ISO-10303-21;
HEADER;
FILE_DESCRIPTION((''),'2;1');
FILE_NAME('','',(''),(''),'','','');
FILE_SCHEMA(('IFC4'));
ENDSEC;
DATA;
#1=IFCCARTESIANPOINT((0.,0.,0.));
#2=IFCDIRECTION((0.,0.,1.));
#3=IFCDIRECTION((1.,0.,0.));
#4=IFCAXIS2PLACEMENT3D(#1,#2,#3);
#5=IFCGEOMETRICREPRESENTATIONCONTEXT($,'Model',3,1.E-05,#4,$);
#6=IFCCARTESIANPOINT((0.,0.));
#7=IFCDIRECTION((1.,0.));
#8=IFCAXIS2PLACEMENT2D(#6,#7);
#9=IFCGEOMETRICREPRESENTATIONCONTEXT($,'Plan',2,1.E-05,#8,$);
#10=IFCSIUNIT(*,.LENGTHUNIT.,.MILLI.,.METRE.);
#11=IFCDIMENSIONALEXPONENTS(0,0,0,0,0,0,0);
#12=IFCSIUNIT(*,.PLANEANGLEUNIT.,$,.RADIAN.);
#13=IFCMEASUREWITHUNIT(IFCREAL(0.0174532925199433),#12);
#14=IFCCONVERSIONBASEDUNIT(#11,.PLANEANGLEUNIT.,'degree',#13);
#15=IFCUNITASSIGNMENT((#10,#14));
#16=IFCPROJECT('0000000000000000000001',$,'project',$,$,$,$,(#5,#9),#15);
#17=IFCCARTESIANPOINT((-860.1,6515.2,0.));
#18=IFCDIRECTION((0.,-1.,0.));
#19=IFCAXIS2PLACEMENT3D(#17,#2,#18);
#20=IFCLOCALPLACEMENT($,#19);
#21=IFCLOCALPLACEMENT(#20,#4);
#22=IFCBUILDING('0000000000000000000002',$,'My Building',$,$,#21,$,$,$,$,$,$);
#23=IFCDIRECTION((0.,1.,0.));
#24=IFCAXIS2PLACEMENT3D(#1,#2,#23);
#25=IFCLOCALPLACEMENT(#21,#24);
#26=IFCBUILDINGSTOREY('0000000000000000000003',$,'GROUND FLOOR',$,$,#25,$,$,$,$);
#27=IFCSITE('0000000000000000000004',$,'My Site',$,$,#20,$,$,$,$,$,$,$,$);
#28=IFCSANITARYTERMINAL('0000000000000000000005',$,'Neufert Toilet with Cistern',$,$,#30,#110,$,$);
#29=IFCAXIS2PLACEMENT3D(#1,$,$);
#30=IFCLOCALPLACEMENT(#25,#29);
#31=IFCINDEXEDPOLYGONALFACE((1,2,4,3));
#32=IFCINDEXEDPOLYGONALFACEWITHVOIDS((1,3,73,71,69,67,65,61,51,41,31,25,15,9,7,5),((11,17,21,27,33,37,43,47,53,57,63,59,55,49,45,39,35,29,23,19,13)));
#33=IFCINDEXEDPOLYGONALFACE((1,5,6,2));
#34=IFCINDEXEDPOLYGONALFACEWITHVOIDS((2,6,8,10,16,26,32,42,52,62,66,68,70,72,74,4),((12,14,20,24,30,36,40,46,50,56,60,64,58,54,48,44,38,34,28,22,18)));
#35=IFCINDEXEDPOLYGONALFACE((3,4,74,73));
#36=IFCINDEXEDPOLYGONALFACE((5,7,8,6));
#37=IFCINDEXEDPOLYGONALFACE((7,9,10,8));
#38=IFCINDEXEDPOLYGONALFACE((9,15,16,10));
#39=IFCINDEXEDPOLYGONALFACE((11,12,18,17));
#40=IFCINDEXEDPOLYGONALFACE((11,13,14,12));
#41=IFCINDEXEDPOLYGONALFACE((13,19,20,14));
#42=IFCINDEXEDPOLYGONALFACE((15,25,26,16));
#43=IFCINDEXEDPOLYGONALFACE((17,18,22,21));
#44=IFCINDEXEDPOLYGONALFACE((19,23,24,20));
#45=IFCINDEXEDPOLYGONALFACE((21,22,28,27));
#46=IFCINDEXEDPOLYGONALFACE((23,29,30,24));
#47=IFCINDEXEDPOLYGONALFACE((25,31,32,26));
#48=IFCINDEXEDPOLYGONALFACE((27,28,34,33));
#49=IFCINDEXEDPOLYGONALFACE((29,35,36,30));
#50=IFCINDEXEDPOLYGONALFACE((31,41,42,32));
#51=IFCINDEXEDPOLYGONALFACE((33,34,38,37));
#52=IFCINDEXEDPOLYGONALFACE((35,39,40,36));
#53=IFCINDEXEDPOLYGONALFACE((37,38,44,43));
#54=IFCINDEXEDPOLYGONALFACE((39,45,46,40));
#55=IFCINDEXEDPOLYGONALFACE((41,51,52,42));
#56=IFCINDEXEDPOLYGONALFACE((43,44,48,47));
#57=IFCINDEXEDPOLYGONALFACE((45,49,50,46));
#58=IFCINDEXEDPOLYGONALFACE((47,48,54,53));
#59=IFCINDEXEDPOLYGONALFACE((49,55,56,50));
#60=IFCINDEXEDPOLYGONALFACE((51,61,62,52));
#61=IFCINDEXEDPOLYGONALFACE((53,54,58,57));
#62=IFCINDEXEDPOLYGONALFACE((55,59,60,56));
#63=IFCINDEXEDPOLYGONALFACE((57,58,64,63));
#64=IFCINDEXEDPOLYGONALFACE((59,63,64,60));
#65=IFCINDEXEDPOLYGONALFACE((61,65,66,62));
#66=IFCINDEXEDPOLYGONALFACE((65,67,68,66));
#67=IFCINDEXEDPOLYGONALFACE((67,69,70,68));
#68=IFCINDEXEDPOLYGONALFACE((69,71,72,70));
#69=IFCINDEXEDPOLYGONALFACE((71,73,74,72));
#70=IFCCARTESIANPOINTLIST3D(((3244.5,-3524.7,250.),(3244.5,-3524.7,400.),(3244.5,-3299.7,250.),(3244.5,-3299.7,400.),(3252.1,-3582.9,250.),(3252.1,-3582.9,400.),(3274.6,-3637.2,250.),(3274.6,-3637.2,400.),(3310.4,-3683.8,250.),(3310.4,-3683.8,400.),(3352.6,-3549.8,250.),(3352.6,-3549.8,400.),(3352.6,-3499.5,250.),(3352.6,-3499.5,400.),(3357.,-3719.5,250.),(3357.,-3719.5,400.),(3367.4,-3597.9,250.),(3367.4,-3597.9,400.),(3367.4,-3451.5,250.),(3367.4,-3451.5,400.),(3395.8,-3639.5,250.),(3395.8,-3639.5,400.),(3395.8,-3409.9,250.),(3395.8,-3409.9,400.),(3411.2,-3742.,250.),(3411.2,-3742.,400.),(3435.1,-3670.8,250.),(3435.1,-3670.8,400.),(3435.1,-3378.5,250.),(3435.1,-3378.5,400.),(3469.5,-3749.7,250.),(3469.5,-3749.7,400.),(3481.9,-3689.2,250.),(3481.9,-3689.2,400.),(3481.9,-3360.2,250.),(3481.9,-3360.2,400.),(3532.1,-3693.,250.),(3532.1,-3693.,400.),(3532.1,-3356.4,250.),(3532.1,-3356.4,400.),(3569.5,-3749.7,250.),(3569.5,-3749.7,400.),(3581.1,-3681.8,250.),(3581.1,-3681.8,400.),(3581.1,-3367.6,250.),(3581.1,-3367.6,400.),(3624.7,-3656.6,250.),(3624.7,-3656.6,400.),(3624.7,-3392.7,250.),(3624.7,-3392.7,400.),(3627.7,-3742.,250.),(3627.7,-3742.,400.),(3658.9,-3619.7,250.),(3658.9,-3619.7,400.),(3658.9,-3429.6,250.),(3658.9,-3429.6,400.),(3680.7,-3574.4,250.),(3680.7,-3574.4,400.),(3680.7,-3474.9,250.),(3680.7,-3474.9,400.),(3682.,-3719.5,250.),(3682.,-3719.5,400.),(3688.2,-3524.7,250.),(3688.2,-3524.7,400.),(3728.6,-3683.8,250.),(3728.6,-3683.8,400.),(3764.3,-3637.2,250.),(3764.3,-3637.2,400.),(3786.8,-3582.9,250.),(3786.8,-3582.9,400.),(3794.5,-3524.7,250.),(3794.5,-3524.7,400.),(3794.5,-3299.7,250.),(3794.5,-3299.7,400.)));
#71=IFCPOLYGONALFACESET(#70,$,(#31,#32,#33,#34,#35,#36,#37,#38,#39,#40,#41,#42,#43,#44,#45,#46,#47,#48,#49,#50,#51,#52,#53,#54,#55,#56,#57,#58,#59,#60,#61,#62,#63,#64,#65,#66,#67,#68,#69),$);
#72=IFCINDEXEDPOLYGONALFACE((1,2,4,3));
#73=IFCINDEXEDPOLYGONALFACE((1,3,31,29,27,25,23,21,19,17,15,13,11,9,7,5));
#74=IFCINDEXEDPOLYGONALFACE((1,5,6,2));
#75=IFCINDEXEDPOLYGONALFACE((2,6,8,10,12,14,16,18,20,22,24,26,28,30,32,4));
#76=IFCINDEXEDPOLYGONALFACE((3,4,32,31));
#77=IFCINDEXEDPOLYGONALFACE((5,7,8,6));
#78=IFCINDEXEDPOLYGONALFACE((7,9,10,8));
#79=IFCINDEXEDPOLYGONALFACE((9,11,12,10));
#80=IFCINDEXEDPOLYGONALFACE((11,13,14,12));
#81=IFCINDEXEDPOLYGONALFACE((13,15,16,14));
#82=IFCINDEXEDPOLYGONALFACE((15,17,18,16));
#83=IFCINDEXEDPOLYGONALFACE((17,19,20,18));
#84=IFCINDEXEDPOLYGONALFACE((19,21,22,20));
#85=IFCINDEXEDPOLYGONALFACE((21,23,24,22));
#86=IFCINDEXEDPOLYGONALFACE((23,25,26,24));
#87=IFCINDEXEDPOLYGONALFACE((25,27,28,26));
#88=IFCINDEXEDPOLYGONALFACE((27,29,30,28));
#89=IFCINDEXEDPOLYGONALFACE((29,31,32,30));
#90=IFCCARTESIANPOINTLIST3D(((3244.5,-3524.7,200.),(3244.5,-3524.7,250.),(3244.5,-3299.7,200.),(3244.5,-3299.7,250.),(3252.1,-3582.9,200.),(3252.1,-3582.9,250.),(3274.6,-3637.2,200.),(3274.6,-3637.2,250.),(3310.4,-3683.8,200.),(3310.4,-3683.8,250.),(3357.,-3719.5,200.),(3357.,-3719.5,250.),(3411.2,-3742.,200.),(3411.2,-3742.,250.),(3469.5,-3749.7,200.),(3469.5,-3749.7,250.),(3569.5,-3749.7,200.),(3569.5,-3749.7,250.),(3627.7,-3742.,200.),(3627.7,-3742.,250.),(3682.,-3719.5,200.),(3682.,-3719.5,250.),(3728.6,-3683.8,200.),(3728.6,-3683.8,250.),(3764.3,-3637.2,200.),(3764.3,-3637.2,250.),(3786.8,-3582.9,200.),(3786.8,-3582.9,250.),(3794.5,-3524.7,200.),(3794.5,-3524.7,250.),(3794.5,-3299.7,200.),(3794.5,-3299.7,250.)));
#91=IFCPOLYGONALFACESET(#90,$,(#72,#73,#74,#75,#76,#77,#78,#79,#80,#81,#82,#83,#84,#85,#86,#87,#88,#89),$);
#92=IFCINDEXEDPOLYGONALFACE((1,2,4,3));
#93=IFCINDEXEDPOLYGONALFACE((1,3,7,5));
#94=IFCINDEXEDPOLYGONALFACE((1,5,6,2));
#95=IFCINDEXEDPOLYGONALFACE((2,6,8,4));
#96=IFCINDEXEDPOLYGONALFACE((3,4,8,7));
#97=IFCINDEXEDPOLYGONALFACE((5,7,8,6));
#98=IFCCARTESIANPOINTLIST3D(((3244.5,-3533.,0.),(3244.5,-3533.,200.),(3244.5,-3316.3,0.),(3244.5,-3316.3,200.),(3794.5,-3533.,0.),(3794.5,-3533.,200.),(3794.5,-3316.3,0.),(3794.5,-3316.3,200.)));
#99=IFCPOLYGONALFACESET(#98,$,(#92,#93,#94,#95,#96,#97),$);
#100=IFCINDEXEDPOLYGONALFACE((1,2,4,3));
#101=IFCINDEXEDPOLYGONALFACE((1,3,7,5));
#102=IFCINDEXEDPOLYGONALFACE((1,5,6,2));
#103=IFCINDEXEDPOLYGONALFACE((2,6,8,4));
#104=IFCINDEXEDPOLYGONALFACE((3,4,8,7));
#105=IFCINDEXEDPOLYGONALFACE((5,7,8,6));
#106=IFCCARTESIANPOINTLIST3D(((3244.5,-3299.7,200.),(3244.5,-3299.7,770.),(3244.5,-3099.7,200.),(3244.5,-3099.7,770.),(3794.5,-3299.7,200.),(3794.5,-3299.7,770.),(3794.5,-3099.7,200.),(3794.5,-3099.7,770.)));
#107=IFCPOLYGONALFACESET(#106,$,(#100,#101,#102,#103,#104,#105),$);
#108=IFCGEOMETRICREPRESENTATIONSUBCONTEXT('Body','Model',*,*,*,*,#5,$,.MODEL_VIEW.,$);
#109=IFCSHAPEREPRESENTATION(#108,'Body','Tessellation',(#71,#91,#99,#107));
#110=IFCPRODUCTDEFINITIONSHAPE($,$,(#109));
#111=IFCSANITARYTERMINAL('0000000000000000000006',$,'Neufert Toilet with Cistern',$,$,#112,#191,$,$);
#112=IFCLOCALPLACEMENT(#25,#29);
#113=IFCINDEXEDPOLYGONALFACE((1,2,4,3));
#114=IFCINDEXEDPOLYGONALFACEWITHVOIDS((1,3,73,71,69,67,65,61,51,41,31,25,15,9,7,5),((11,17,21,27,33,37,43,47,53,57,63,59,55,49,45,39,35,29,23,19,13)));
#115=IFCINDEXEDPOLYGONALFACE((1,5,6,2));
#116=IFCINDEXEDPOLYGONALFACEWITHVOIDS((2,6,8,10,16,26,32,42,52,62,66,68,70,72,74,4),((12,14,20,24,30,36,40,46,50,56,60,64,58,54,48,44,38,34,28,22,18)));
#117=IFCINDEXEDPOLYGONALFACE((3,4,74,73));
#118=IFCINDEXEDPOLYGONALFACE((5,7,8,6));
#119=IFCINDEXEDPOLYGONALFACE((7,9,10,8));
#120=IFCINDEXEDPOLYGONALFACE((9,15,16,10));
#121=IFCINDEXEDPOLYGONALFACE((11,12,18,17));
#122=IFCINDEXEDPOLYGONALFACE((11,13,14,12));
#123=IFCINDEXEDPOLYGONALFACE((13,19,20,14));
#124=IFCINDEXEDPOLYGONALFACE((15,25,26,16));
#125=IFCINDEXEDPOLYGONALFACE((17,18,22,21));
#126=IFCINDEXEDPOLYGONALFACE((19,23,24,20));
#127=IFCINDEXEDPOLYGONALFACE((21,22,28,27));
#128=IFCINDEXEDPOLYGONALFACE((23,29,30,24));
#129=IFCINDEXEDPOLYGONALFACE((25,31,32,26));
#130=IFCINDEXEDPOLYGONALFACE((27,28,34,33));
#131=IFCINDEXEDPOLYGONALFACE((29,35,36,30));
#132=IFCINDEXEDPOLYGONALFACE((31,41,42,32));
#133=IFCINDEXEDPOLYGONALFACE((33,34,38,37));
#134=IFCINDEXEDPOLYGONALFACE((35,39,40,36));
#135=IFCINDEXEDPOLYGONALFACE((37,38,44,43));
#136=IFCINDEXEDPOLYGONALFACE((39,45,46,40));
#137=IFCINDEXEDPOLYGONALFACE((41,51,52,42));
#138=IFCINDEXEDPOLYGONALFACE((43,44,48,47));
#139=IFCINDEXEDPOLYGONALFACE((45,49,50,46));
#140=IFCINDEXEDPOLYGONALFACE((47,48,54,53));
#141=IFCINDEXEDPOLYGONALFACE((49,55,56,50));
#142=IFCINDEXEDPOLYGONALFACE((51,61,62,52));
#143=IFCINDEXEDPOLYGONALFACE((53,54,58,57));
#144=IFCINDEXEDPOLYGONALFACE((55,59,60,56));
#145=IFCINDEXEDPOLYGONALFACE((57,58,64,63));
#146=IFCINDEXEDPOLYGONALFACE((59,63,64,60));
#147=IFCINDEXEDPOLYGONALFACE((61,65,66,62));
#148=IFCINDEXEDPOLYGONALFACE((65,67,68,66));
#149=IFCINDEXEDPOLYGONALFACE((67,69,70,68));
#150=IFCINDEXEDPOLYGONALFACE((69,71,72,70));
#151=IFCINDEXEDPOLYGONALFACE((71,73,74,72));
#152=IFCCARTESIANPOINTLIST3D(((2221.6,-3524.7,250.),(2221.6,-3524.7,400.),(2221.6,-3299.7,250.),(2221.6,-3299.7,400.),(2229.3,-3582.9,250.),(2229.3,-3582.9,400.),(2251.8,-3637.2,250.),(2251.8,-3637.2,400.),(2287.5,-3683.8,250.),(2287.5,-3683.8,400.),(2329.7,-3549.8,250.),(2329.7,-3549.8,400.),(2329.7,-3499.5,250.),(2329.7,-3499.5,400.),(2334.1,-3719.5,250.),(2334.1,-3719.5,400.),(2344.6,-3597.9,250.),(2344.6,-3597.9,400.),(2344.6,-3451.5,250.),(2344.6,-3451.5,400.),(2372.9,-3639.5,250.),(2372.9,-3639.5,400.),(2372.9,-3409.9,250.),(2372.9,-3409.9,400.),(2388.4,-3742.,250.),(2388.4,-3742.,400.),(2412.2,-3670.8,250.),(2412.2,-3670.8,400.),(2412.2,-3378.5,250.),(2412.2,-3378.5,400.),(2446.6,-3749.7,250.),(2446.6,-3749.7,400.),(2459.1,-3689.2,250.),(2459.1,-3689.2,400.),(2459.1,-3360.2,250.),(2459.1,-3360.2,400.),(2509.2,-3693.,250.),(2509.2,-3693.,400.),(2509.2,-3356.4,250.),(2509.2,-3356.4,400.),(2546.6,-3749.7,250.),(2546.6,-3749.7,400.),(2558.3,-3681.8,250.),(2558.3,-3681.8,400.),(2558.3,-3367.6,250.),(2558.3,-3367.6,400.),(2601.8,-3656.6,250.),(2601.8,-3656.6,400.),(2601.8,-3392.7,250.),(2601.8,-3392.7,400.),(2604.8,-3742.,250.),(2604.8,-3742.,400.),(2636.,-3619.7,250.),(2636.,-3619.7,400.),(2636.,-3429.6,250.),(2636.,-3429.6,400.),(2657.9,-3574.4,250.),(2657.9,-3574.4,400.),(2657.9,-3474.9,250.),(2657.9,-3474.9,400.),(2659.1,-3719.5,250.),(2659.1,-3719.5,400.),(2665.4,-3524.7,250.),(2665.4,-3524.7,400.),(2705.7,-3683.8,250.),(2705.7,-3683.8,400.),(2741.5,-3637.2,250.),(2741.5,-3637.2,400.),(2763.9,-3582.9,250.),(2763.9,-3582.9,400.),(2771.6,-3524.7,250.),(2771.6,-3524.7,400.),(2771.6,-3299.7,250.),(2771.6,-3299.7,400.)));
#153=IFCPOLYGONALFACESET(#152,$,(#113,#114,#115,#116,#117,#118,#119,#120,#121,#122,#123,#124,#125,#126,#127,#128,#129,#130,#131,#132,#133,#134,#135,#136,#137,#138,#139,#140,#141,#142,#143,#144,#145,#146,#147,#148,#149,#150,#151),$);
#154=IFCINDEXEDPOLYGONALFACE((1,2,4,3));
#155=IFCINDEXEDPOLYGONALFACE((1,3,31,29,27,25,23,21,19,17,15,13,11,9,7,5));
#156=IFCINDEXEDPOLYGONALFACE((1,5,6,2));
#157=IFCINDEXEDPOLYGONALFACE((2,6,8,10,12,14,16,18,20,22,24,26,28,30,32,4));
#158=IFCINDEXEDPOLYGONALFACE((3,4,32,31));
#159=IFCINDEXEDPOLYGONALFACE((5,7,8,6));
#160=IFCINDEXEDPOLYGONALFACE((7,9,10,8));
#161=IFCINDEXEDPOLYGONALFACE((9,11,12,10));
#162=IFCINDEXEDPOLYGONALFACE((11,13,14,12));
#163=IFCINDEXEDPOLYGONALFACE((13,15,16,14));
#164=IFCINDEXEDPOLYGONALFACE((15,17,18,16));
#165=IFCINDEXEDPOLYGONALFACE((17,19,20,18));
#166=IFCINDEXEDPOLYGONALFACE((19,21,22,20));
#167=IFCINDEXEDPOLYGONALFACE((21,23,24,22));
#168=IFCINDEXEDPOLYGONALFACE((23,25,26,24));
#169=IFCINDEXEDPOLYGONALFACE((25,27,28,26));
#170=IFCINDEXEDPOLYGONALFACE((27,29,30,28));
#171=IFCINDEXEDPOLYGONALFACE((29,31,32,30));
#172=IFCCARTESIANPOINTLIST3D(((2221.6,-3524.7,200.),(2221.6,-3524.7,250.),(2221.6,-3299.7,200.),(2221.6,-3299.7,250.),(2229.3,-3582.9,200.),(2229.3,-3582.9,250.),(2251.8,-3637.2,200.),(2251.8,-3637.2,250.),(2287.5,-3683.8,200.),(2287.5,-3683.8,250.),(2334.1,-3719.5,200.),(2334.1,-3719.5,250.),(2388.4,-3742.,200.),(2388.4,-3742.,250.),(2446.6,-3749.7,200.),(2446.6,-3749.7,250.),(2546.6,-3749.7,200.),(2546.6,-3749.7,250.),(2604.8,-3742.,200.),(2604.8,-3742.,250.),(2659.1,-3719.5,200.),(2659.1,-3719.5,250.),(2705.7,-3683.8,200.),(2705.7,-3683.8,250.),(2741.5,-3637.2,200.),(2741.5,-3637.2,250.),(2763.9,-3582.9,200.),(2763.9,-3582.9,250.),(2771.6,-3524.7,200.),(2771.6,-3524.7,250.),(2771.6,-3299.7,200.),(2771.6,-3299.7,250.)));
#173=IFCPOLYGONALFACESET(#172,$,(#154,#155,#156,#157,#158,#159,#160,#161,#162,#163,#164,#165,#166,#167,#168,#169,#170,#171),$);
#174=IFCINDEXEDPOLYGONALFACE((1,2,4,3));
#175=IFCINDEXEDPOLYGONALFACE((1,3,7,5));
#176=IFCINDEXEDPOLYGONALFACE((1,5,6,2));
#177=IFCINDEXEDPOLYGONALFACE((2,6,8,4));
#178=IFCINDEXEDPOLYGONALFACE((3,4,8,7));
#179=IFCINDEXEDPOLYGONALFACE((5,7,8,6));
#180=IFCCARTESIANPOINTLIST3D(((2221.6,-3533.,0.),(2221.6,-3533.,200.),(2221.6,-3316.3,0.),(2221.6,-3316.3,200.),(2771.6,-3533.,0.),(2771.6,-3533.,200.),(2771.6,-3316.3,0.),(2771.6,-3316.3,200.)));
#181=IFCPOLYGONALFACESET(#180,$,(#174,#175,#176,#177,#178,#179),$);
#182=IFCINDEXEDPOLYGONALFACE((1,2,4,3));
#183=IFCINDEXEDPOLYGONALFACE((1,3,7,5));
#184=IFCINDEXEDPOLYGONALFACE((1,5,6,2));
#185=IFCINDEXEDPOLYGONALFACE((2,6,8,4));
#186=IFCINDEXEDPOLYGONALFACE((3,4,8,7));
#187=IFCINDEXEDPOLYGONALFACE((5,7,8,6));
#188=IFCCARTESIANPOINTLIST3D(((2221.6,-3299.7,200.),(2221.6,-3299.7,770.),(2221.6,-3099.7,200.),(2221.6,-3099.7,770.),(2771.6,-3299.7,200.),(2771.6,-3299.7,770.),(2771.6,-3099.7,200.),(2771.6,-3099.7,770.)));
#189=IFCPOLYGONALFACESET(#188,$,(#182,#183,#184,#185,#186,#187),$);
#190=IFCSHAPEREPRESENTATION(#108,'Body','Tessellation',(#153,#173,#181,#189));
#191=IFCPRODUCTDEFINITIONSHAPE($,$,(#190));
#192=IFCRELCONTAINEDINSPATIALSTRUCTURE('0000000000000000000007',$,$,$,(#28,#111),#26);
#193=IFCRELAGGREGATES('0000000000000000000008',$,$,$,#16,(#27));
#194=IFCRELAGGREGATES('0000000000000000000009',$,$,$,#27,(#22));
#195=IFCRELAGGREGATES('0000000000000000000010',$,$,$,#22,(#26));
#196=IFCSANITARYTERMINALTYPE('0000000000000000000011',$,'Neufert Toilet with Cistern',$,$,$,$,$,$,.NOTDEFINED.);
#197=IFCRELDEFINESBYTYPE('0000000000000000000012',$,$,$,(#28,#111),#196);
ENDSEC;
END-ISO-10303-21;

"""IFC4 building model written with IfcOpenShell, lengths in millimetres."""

from ifc_helpers import new_model, entity, si_unit, converted_unit, frame, frame_2d, origin_with_axes, origin_2d_with_axis, place, context, subcontext, project, spatial, line, arc, indexed_curve, circle_curve, outline, extrude, shape, source, transform, mapped, type_object, type_shapes, element, save


model = new_model("IFC4")

# Units and contexts
model_context = context("Model", 3, precision=1e-05, world=origin_with_axes())
plan_context = context("Plan", 2, precision=1e-05, world=origin_2d_with_axis())
body_context_1 = subcontext(model_context, "Body", "Model", "MODEL_VIEW")
body_context_2 = subcontext(plan_context, "Body", "Plan", "PLAN_VIEW")
ifc_project = project(units=[si_unit("LENGTHUNIT", "METRE", prefix="MILLI"), converted_unit("PLANEANGLEUNIT", "degree", entity("IfcReal", 0.0174532925199433), si_unit("PLANEANGLEUNIT", "RADIAN"), dimensions=[0, 0, 0, 0, 0, 0, 0])], contexts=[model_context, plan_context])

# Site, building, storey
site_placement = place(None, frame((-860.1, 6515.2, 0.0), z_axis=(0.0, 0.0, 1.0), x_axis=(0.0, -1.0, 0.0)))
site = spatial("IfcSite", under=ifc_project, at=site_placement, Name="My Site")
building_placement = place(site_placement, frame((0.0, 0.0, 0.0), z_axis=(0.0, 0.0, 1.0), x_axis=(1.0, 0.0, 0.0)))
building = spatial("IfcBuilding", under=site, at=building_placement, Name="My Building")
storey_placement = place(building_placement, frame((0.0, 0.0, 0.0), z_axis=(0.0, 0.0, 1.0), x_axis=(0.0, 1.0, 0.0)))
storey = spatial("IfcBuildingStorey", under=building, at=storey_placement, Name="GROUND FLOOR")

# Sanitary terminals
sanitary_terminal_type_1 = type_object("IfcSanitaryTerminalType", Name="Neufert Toilet with Cistern", PredefinedType="NOTDEFINED")
shared_shape_1 = source(origin_with_axes(), body_context_1, "Body", "SweptSolid", [
    extrude(outline(indexed_curve([(-275.0, -200.0), (275.0, -200.0), (275.0, -425.0), (209.1, -584.1), (50.0, -650.0), (-50.0, -650.0), (-209.1, -584.1), (-275.0, -425.0)], segments=[line(1, 2), line(2, 3), arc(3, 4, 5), line(5, 6), arc(6, 7, 8), line(8, 1)]), holes=[circle_curve(frame_2d((0.0, -425.0)), 168.8)]), frame((0.0, 0.0, 250.0), z_axis=(0.0, 0.0, 1.0), x_axis=(1.0, 0.0, 0.0)), (0.0, 0.0, 1.0), 150.0),
    extrude(outline(indexed_curve([(-275.0, -200.0), (275.0, -200.0), (275.0, -425.0), (209.1, -584.1), (50.0, -650.0), (-50.0, -650.0), (-209.1, -584.1), (-275.0, -425.0)], segments=[line(1, 2), line(2, 3), arc(3, 4, 5), line(5, 6), arc(6, 7, 8), line(8, 1)])), frame((0.0, 0.0, 200.0), z_axis=(0.0, 0.0, 1.0), x_axis=(1.0, 0.0, 0.0)), (0.0, 0.0, 1.0), 50.0),
    extrude(outline(indexed_curve([(-275.0, -216.7), (275.0, -216.7), (275.0, -433.3), (-275.0, -433.3)], segments=[line(1, 2), line(2, 3), line(3, 4), line(4, 1)])), origin_with_axes(), (0.0, 0.0, 1.0), 200.0),
    extrude(outline(indexed_curve([(-275.0, 0.0), (275.0, 0.0), (275.0, -200.0), (-275.0, -200.0)], segments=[line(1, 2), line(2, 3), line(3, 4), line(4, 1)])), frame((0.0, 0.0, 200.0), z_axis=(0.0, 0.0, 1.0), x_axis=(1.0, 0.0, 0.0)), (0.0, 0.0, 1.0), 570.0),
])
shared_shape_2 = source(origin_with_axes(), body_context_2, "Body", "Curve2D", [
    entity("IfcIndexedPolyCurve", entity("IfcCartesianPointList2D", [[-275.0, 0.0], [275.0, 0.0], [275.0, -200.0], [-275.0, -200.0]]), [entity("IfcLineIndex", [1, 2]), entity("IfcLineIndex", [2, 3]), entity("IfcLineIndex", [3, 4]), entity("IfcLineIndex", [4, 1])]),
    entity("IfcIndexedPolyCurve", entity("IfcCartesianPointList2D", [[165.0, -200.0], [192.5, -335.0]]), [entity("IfcLineIndex", [1, 2])]),
    entity("IfcTrimmedCurve", entity("IfcEllipse", entity("IfcAxis2Placement2D", entity("IfcCartesianPoint", [0.0, -335.0]), entity("IfcDirection", [1.0, 0.0])), 192.5, 315.0), [entity("IfcCartesianPoint", [-192.5, -335.0])], [entity("IfcCartesianPoint", [192.5, -335.0])], True, "CARTESIAN"),
    entity("IfcIndexedPolyCurve", entity("IfcCartesianPointList2D", [[-165.0, -200.0], [-192.5, -335.0]]), [entity("IfcLineIndex", [1, 2])]),
    entity("IfcEllipse", entity("IfcAxis2Placement2D", entity("IfcCartesianPoint", [0.0, -452.0]), entity("IfcDirection", [1.0, 0.0])), 131.2, 157.5),
    entity("IfcIndexedPolyCurve", entity("IfcCartesianPointList2D", [[-34.4, -452.0], [-34.4, -429.5], [34.4, -429.5], [34.4, -452.0]]), [entity("IfcLineIndex", [1, 2]), entity("IfcLineIndex", [2, 3]), entity("IfcLineIndex", [3, 4])]),
    entity("IfcTrimmedCurve", entity("IfcEllipse", entity("IfcAxis2Placement2D", entity("IfcCartesianPoint", [0.0, -452.0]), entity("IfcDirection", [1.0, 0.0])), 34.4, 22.5), [entity("IfcCartesianPoint", [-34.4, -452.0])], [entity("IfcCartesianPoint", [34.4, -452.0])], True, "CARTESIAN"),
])
type_shapes(sanitary_terminal_type_1, [shared_shape_1, shared_shape_2])
for number, where, z_axis, x_axis, name in (
    (1, (3519.5, -3099.7, 0.0), (0.0, 0.0, 1.0), (1.0, 0.0, 0.0), "Neufert Toilet with Cistern"),
    (2, (2496.6, -3099.7, 0.0), (0.0, 0.0, 1.0), (1.0, 0.0, 0.0), "Neufert Toilet with Cistern"),
):
    element("IfcSanitaryTerminal", number, at=place(storey_placement, frame(where, z_axis=z_axis, x_axis=x_axis)), inside=storey, type_object=sanitary_terminal_type_1, Name=name, shapes=[
        shape(body_context_1, "Body", "MappedRepresentation", [mapped(shared_shape_1, transform((0.0, 0.0, 0.0), x_axis=(1.0, 0.0, 0.0), y_axis=(0.0, 1.0, 0.0), z_axis=(0.0, 0.0, 1.0), scale=1.0))]),
        shape(body_context_2, "Body", "MappedRepresentation", [mapped(shared_shape_2, transform((0.0, 0.0, 0.0), x_axis=(1.0, 0.0, 0.0), y_axis=(0.0, 1.0, 0.0), z_axis=(0.0, 0.0, 1.0), scale=1.0))]),
    ])

save(model, "model.ifc")
